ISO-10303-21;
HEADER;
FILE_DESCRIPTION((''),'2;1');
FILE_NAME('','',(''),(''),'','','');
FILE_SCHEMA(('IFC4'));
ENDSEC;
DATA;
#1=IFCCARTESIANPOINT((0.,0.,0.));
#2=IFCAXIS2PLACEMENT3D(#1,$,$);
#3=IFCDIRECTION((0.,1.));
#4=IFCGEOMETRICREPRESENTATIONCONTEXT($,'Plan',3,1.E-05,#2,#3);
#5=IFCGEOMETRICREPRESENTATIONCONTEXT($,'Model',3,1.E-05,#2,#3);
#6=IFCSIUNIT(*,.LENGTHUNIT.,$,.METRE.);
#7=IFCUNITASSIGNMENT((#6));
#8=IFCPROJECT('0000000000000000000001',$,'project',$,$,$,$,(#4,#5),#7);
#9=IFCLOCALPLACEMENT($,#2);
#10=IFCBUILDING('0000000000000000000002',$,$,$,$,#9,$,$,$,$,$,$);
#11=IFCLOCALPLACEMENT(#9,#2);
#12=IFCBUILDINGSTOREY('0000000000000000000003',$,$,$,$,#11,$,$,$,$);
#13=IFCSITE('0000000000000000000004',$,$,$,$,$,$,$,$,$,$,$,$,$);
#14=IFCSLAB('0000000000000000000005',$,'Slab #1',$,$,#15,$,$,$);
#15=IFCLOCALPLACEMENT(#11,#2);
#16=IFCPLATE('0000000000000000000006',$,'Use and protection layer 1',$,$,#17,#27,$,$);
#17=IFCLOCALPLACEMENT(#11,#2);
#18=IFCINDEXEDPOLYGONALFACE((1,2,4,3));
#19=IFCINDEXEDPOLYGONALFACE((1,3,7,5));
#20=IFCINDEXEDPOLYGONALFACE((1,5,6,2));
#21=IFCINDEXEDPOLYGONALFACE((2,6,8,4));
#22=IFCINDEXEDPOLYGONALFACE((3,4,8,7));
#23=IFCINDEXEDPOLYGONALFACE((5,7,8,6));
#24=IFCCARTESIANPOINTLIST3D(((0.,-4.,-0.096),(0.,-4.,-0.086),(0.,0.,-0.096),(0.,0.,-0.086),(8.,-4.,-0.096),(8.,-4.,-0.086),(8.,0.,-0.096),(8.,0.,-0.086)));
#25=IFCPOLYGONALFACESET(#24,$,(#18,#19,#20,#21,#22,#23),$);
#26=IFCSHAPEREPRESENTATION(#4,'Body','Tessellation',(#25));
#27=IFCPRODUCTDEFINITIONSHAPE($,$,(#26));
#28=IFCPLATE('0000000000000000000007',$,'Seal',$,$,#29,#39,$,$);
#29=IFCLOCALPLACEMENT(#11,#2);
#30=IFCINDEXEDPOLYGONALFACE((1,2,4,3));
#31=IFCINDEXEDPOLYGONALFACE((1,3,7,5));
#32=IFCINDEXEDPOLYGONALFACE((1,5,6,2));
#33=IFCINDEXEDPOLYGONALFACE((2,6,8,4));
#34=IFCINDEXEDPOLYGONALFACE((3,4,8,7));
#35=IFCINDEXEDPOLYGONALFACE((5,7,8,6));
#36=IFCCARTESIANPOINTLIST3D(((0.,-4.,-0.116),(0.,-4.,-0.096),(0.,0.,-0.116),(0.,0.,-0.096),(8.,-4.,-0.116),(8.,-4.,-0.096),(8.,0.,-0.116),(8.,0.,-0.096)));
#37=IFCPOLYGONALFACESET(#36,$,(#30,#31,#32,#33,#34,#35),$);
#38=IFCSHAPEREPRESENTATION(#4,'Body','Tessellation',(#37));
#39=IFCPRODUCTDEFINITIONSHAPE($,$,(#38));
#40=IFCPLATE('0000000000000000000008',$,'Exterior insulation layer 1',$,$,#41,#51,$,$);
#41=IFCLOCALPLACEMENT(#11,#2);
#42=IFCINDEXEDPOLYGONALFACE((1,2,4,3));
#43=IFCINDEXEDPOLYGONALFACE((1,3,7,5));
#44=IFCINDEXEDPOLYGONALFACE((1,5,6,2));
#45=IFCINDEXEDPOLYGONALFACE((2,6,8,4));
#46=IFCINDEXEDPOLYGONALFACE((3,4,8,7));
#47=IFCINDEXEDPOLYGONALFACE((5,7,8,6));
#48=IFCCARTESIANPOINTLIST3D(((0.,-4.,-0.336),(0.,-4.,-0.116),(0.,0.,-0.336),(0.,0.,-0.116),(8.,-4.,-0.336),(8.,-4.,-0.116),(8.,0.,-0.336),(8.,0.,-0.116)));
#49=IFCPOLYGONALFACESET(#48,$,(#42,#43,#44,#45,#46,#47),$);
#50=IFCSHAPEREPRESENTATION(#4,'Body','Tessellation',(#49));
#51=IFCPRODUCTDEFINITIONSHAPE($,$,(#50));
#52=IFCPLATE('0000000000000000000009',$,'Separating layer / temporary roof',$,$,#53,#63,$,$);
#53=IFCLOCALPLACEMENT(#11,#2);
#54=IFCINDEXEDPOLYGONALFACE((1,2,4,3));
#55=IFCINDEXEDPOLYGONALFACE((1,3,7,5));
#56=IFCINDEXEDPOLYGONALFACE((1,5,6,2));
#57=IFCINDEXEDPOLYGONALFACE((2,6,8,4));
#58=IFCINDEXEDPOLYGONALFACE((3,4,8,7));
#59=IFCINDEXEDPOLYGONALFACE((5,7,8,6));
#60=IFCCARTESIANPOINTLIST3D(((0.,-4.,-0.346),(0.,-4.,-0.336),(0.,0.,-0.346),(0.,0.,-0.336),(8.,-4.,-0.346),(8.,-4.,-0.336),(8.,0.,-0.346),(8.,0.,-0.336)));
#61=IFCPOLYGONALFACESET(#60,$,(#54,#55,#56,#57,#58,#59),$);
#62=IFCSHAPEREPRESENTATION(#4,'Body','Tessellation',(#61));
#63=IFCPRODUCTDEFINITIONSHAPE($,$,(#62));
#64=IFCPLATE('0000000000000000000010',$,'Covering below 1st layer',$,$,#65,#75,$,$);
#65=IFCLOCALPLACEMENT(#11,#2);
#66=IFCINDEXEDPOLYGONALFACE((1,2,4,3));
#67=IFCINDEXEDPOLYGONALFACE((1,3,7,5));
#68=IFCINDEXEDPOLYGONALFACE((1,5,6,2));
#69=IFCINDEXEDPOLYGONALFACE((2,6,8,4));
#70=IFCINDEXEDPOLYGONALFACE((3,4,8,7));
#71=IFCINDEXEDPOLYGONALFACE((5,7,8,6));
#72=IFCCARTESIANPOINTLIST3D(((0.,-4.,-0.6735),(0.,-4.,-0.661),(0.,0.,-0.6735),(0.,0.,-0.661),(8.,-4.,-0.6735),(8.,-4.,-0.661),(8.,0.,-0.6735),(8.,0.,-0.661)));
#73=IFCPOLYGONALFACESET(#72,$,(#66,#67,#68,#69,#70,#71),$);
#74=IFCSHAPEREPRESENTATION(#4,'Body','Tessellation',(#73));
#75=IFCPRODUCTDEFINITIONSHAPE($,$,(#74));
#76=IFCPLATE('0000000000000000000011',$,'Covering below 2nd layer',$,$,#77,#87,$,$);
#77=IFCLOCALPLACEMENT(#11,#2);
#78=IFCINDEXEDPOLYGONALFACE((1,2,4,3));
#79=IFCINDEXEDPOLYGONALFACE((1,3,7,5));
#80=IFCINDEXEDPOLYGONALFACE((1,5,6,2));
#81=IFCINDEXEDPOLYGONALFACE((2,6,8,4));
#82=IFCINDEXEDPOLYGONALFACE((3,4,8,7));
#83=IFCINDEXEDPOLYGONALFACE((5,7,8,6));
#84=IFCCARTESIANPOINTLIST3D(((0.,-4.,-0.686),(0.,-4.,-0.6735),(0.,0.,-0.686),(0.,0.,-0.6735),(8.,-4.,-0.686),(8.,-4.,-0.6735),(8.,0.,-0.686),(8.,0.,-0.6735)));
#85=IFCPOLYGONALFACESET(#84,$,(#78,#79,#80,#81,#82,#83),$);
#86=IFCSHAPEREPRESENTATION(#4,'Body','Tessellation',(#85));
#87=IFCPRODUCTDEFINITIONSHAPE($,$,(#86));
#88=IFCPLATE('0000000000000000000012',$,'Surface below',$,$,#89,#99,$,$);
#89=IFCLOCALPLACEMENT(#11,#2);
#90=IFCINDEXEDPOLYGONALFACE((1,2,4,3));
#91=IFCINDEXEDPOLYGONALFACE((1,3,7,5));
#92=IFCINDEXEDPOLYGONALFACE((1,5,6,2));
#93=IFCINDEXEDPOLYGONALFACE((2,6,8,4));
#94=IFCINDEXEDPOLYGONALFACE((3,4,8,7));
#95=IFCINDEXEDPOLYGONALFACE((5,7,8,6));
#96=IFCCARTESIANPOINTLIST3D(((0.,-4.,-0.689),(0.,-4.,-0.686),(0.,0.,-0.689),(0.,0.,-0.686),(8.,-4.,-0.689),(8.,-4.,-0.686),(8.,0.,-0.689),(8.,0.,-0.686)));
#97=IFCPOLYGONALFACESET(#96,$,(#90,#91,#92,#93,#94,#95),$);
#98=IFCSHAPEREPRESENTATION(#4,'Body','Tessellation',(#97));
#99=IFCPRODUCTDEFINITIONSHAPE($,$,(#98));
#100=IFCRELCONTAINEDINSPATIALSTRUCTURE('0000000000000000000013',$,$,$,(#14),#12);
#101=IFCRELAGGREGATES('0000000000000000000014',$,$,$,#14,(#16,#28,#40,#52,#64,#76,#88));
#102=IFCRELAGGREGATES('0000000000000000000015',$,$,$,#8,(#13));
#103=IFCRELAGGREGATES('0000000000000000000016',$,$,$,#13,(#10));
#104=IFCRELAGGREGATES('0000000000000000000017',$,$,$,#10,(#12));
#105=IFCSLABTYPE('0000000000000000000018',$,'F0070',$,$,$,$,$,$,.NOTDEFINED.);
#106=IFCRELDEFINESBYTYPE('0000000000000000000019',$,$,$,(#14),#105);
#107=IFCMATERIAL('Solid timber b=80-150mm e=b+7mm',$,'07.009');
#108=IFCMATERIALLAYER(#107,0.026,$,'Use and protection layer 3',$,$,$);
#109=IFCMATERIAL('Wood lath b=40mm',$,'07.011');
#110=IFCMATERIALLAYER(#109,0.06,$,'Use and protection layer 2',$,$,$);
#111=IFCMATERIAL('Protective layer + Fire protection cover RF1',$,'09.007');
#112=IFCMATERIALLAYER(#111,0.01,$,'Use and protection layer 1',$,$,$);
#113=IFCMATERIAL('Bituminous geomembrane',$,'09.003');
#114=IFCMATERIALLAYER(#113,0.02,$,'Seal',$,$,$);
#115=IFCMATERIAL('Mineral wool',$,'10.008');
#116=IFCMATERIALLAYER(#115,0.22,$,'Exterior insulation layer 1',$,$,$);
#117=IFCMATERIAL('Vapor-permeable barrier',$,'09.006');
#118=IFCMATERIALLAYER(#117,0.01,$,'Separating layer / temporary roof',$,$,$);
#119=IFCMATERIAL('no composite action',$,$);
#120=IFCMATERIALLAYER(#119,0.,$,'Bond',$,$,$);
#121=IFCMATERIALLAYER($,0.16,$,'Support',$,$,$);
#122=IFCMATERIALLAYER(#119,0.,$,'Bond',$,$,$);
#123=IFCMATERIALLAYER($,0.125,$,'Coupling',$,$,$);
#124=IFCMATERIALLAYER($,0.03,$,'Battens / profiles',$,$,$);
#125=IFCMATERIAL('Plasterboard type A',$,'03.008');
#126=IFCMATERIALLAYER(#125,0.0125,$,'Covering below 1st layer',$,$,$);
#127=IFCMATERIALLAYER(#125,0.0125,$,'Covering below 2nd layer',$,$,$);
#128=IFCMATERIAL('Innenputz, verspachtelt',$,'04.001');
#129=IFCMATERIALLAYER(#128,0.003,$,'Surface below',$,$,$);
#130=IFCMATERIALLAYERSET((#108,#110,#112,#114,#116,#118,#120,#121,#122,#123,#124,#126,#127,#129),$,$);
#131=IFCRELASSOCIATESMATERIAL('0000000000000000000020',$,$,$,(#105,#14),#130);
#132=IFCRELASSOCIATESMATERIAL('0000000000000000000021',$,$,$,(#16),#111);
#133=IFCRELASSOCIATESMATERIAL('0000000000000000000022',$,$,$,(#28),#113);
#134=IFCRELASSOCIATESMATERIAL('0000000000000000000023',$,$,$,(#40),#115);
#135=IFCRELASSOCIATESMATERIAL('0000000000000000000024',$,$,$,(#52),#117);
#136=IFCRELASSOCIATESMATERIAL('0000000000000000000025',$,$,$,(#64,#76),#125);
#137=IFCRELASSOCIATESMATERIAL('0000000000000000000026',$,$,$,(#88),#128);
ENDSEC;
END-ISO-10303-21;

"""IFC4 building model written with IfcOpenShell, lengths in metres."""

from ifc_helpers import new_model, si_unit, direction, frame, frame_2d, origin, place, context, project, spatial, rectangle, extrude, material, layer, layer_set, type_object, element, aggregate, save


model = new_model("IFC4")

# Units and contexts
plan_context = context("Plan", 3, precision=1e-05, world=origin(), true_north=direction((0.0, 1.0)))
model_context = context("Model", 3, precision=1e-05, world=origin(), true_north=direction((0.0, 1.0)))
ifc_project = project(units=[si_unit("LENGTHUNIT", "METRE")], contexts=[plan_context, model_context])

# Site, building, storey
site = spatial("IfcSite", under=ifc_project)
building_placement = place(None, origin())
building = spatial("IfcBuilding", under=site, at=building_placement)
storey_placement = place(building_placement, origin())
storey = spatial("IfcBuildingStorey", under=building, at=storey_placement)

# Slab, plates
ifc_material_1 = material(Name="Solid timber b=80-150mm e=b+7mm", Category="07.009")
ifc_layer_1 = layer(ifc_material_1, 0.026, Name="Use and protection layer 3")
ifc_material_2 = material(Name="Wood lath b=40mm", Category="07.011")
ifc_layer_2 = layer(ifc_material_2, 0.06, Name="Use and protection layer 2")
ifc_material_3 = material(Name="Protective layer + Fire protection cover RF1", Category="09.007")
ifc_layer_3 = layer(ifc_material_3, 0.01, Name="Use and protection layer 1")
ifc_material_4 = material(Name="Bituminous geomembrane", Category="09.003")
ifc_layer_4 = layer(ifc_material_4, 0.02, Name="Seal")
ifc_material_5 = material(Name="Mineral wool", Category="10.008")
ifc_layer_5 = layer(ifc_material_5, 0.22, Name="Exterior insulation layer 1")
ifc_material_6 = material(Name="Vapor-permeable barrier", Category="09.006")
ifc_layer_6 = layer(ifc_material_6, 0.01, Name="Separating layer / temporary roof")
ifc_material_7 = material(Name="no composite action")
ifc_layer_7 = layer(ifc_material_7, 0.0, Name="Bond")
ifc_layer_8 = layer(None, 0.16, Name="Support")
ifc_layer_9 = layer(ifc_material_7, 0.0, Name="Bond")
ifc_layer_10 = layer(None, 0.125, Name="Coupling")
ifc_layer_11 = layer(None, 0.03, Name="Battens / profiles")
ifc_material_8 = material(Name="Plasterboard type A", Category="03.008")
ifc_layer_12 = layer(ifc_material_8, 0.0125, Name="Covering below 1st layer")
ifc_layer_13 = layer(ifc_material_8, 0.0125, Name="Covering below 2nd layer")
ifc_material_9 = material(Name="Innenputz, verspachtelt", Category="04.001")
ifc_layer_14 = layer(ifc_material_9, 0.003, Name="Surface below")
ifc_layer_set = layer_set([ifc_layer_1, ifc_layer_2, ifc_layer_3, ifc_layer_4, ifc_layer_5, ifc_layer_6, ifc_layer_7, ifc_layer_8, ifc_layer_9, ifc_layer_10, ifc_layer_11, ifc_layer_12, ifc_layer_13, ifc_layer_14])
slab_type = type_object("IfcSlabType", Name="F0070", PredefinedType="NOTDEFINED", material=ifc_layer_set)
slab_placement = place(None, frame((0.0, 0.0, 0.0), z_axis=(0.0, 0.0, -1.0), x_axis=(1.0, 0.0, 0.0)))
slab = element("IfcSlab", 1, at=slab_placement, inside=storey, type_object=slab_type, material=ifc_layer_set, Name="Slab #1")
plate_1_placement = place(slab_placement, origin())
plate_1 = element("IfcPlate", 2, at=plate_1_placement, material=ifc_material_3, Name="Use and protection layer 1", context=plan_context, shape_type="SweptSolid", body=[
    extrude(rectangle(XDim=8.0, YDim=4.0, at=frame_2d((4.0, 2.0), x_axis=(1.0, 0.0))), frame((0.0, 0.0, 0.086), z_axis=(0.0, 0.0, 1.0), x_axis=(1.0, 0.0, 0.0)), (0.0, 0.0, 1.0), 0.01),
])
plate_2_placement = place(slab_placement, origin())
plate_2 = element("IfcPlate", 3, at=plate_2_placement, material=ifc_material_4, Name="Seal", context=plan_context, shape_type="SweptSolid", body=[
    extrude(rectangle(XDim=8.0, YDim=4.0, at=frame_2d((4.0, 2.0), x_axis=(1.0, 0.0))), frame((0.0, 0.0, 0.096), z_axis=(0.0, 0.0, 1.0), x_axis=(1.0, 0.0, 0.0)), (0.0, 0.0, 1.0), 0.02),
])
plate_3_placement = place(slab_placement, origin())
plate_3 = element("IfcPlate", 4, at=plate_3_placement, material=ifc_material_5, Name="Exterior insulation layer 1", context=plan_context, shape_type="SweptSolid", body=[
    extrude(rectangle(XDim=8.0, YDim=4.0, at=frame_2d((4.0, 2.0), x_axis=(1.0, 0.0))), frame((0.0, 0.0, 0.116), z_axis=(0.0, 0.0, 1.0), x_axis=(1.0, 0.0, 0.0)), (0.0, 0.0, 1.0), 0.22),
])
plate_4_placement = place(slab_placement, origin())
plate_4 = element("IfcPlate", 5, at=plate_4_placement, material=ifc_material_6, Name="Separating layer / temporary roof", context=plan_context, shape_type="SweptSolid", body=[
    extrude(rectangle(XDim=8.0, YDim=4.0, at=frame_2d((4.0, 2.0), x_axis=(1.0, 0.0))), frame((0.0, 0.0, 0.336), z_axis=(0.0, 0.0, 1.0), x_axis=(1.0, 0.0, 0.0)), (0.0, 0.0, 1.0), 0.01),
])
plate_5_placement = place(slab_placement, origin())
plate_5 = element("IfcPlate", 6, at=plate_5_placement, material=ifc_material_8, Name="Covering below 1st layer", context=plan_context, shape_type="SweptSolid", body=[
    extrude(rectangle(XDim=8.0, YDim=4.0, at=frame_2d((4.0, 2.0), x_axis=(1.0, 0.0))), frame((0.0, 0.0, 0.661), z_axis=(0.0, 0.0, 1.0), x_axis=(1.0, 0.0, 0.0)), (0.0, 0.0, 1.0), 0.0125),
])
plate_6_placement = place(slab_placement, origin())
plate_6 = element("IfcPlate", 7, at=plate_6_placement, material=ifc_material_8, Name="Covering below 2nd layer", context=plan_context, shape_type="SweptSolid", body=[
    extrude(rectangle(XDim=8.0, YDim=4.0, at=frame_2d((4.0, 2.0), x_axis=(1.0, 0.0))), frame((0.0, 0.0, 0.6735), z_axis=(0.0, 0.0, 1.0), x_axis=(1.0, 0.0, 0.0)), (0.0, 0.0, 1.0), 0.0125),
])
plate_7_placement = place(slab_placement, origin())
plate_7 = element("IfcPlate", 8, at=plate_7_placement, material=ifc_material_9, Name="Surface below", context=plan_context, shape_type="SweptSolid", body=[
    extrude(rectangle(XDim=8.0, YDim=4.0, at=frame_2d((4.0, 2.0), x_axis=(1.0, 0.0))), frame((0.0, 0.0, 0.686), z_axis=(0.0, 0.0, 1.0), x_axis=(1.0, 0.0, 0.0)), (0.0, 0.0, 1.0), 0.003),
])
aggregate(slab, [plate_1, plate_2, plate_3, plate_4, plate_5, plate_6, plate_7])

save(model, "model.ifc")
